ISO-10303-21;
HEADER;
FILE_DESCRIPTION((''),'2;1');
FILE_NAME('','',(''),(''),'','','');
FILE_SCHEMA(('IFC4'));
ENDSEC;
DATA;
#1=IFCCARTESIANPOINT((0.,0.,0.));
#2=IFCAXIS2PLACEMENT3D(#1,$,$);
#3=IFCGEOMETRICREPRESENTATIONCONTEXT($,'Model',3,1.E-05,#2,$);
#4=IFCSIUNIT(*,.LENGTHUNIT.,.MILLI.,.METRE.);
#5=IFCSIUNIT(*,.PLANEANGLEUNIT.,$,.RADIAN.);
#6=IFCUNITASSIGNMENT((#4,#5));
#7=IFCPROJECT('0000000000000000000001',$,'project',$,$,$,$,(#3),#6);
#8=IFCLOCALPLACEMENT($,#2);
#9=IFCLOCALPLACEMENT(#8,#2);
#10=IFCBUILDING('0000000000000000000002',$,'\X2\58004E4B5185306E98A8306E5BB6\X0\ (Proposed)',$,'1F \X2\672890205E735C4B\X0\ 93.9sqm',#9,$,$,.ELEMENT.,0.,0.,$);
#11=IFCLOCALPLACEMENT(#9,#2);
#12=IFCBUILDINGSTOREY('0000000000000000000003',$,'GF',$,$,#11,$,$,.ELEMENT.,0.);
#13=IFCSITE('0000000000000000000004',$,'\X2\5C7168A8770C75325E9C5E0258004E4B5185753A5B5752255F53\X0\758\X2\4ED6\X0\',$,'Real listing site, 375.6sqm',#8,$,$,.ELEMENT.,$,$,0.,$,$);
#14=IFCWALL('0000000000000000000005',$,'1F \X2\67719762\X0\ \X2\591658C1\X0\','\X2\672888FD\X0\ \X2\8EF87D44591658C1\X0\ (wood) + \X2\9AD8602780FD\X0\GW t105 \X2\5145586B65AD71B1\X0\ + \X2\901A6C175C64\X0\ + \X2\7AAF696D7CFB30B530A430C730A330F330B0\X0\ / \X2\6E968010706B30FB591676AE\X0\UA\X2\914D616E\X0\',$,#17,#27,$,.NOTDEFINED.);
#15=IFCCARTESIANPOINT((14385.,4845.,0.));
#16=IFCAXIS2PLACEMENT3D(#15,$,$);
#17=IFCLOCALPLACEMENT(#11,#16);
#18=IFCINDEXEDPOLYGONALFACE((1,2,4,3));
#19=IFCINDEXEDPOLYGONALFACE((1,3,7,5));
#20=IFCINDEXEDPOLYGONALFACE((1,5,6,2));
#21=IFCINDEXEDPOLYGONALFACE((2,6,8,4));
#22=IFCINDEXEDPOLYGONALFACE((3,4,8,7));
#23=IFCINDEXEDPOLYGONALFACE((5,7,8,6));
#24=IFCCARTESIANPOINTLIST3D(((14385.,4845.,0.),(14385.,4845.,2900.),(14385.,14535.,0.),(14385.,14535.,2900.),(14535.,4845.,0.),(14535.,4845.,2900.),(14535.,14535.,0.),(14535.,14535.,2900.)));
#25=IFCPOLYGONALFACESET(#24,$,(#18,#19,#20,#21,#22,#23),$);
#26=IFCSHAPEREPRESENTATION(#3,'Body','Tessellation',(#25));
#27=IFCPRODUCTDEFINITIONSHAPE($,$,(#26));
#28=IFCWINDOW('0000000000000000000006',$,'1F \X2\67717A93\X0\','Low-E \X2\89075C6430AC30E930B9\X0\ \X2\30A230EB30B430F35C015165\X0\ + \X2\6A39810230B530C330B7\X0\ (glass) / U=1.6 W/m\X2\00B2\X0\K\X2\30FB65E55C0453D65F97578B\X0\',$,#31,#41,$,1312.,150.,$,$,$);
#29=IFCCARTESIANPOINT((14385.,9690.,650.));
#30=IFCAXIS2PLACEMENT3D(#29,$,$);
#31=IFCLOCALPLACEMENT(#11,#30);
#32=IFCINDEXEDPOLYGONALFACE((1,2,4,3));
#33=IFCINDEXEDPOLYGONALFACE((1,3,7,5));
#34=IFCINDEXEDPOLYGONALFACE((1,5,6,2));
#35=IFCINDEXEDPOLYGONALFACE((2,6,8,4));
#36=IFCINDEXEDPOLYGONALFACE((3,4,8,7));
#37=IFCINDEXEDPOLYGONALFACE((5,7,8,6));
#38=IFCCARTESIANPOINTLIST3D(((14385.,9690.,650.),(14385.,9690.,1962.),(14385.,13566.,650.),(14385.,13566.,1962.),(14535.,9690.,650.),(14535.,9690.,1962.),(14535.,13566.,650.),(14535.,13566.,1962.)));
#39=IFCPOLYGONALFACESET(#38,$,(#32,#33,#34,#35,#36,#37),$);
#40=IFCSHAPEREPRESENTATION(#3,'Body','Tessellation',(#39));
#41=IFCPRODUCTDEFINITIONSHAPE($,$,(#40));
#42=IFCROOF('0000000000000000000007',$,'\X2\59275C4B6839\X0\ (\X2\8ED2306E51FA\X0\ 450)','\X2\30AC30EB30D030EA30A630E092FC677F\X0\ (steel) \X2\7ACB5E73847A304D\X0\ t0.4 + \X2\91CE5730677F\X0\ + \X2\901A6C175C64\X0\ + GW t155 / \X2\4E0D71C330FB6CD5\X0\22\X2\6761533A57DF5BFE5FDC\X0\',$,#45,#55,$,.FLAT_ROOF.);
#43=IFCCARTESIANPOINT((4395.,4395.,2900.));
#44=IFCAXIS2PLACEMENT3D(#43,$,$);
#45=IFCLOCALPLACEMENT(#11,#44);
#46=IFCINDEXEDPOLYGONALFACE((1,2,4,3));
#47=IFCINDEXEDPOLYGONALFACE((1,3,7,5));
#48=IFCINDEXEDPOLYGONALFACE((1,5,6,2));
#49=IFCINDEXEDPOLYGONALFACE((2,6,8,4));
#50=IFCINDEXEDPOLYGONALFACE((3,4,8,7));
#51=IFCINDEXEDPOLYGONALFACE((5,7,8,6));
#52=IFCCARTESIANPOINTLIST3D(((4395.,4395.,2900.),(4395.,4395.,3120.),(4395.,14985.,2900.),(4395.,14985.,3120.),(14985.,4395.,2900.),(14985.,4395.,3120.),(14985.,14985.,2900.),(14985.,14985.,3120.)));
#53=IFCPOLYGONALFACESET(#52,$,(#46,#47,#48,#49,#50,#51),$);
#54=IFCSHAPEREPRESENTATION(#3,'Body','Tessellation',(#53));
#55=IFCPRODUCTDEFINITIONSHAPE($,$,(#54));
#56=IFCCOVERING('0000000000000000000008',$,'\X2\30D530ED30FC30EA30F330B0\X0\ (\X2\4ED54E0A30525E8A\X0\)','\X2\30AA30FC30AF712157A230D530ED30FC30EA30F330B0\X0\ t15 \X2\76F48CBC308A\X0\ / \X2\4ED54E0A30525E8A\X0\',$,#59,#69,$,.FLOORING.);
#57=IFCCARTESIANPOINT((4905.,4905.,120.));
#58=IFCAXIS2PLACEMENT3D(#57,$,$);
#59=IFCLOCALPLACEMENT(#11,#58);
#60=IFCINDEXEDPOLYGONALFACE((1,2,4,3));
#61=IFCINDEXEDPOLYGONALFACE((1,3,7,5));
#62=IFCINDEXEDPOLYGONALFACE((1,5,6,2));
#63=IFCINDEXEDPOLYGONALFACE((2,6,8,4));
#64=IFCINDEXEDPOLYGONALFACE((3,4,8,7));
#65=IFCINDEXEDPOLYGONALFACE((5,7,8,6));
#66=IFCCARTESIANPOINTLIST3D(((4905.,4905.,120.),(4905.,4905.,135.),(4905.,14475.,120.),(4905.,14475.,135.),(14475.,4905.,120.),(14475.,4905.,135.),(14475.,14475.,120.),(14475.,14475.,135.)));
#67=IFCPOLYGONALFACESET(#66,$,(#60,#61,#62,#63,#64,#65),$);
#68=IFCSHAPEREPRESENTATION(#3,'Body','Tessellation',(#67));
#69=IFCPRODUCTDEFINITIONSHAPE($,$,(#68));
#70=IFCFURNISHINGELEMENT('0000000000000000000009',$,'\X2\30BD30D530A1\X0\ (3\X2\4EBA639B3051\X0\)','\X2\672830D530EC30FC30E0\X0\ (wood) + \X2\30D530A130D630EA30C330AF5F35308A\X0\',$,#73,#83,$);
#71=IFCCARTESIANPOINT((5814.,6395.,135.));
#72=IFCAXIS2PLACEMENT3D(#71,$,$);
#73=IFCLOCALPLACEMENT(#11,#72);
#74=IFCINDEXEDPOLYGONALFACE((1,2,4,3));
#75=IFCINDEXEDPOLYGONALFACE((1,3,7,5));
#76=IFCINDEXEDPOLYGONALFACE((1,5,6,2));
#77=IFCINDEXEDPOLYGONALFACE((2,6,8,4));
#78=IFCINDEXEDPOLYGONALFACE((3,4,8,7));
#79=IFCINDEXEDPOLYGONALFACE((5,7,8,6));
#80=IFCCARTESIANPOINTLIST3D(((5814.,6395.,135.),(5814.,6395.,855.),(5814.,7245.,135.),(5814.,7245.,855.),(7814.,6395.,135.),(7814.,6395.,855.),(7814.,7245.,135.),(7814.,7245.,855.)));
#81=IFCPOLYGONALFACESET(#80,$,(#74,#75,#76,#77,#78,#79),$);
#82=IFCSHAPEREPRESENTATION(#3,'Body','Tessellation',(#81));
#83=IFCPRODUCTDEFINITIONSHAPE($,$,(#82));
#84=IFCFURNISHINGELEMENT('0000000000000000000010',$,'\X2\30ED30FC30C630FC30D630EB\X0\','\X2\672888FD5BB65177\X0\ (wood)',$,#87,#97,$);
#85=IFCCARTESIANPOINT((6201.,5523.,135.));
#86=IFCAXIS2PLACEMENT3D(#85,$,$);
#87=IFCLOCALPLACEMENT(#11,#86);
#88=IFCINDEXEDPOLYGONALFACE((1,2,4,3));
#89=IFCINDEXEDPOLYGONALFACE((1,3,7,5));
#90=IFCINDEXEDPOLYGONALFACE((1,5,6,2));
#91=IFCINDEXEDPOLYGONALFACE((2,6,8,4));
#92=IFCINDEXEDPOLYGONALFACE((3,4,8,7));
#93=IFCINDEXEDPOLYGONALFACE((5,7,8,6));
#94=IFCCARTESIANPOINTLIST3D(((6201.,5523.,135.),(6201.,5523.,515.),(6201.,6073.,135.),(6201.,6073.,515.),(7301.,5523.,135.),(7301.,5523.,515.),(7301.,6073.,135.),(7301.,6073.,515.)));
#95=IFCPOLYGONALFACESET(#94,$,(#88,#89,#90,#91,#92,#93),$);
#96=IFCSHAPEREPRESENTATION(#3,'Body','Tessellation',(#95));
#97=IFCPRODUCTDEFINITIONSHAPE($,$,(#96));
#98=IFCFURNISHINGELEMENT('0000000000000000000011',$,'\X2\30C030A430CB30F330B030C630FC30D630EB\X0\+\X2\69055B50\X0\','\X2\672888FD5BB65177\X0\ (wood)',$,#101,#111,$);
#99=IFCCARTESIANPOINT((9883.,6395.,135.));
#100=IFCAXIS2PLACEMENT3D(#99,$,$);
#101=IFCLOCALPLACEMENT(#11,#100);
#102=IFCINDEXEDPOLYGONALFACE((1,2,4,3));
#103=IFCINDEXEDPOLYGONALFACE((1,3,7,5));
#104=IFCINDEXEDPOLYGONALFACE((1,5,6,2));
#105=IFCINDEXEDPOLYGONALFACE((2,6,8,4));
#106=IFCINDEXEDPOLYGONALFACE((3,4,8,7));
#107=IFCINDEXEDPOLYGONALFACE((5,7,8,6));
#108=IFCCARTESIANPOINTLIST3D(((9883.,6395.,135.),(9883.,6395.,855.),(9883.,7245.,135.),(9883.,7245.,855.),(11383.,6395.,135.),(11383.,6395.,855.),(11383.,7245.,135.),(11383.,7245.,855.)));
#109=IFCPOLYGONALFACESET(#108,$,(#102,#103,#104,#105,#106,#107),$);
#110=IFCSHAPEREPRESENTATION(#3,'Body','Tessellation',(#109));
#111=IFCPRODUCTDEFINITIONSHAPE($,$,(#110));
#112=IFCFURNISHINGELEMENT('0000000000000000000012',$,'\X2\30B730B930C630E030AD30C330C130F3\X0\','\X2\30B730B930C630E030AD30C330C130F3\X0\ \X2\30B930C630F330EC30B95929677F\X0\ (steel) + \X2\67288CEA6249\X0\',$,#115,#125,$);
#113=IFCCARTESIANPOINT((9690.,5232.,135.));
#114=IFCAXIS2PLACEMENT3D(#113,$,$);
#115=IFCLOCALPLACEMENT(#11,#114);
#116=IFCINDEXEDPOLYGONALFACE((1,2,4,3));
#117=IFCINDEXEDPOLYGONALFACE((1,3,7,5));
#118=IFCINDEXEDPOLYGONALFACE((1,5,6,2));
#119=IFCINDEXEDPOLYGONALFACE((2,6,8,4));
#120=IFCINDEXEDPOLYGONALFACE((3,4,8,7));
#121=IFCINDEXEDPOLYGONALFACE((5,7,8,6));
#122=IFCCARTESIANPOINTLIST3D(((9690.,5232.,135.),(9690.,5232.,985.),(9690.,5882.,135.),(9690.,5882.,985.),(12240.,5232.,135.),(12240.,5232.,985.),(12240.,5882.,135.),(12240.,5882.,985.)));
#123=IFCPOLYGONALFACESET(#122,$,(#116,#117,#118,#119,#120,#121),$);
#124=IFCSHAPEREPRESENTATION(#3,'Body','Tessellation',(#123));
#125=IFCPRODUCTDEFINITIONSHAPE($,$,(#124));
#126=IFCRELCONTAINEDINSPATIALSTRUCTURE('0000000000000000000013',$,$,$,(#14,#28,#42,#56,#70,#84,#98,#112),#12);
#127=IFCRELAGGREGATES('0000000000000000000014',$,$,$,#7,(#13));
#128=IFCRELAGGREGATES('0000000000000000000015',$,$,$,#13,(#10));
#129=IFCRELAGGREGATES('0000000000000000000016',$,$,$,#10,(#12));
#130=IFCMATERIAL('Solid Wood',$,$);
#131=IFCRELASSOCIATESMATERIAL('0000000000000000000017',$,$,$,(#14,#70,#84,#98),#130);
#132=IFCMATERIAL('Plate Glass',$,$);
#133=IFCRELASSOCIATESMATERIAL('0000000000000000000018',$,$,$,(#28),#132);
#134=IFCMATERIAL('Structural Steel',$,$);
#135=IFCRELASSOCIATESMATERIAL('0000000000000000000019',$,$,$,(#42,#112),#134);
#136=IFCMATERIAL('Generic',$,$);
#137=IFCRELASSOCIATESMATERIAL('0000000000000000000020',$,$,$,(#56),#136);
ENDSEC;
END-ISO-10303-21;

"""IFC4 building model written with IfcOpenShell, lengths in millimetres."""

from ifc_helpers import new_model, si_unit, frame, frame_2d, origin, place, context, project, spatial, rectangle, extrude, material, element, fill, save


model = new_model("IFC4")

# Units and contexts
model_context = context("Model", 3, precision=1e-05, world=origin())
ifc_project = project(units=[si_unit("LENGTHUNIT", "METRE", prefix="MILLI"), si_unit("PLANEANGLEUNIT", "RADIAN")], contexts=[model_context])

# Site, building, storey
site_placement = place(None, origin())
site = spatial("IfcSite", under=ifc_project, at=site_placement, Name="山梨県甲府市堀之内町字別当758他", ObjectType="Real listing site, 375.6sqm", CompositionType="ELEMENT", RefElevation=0.0)
building_placement = place(site_placement, origin())
building = spatial("IfcBuilding", under=site, at=building_placement, Name="堀之内の風の家 (Proposed)", ObjectType="1F 木造平屋 93.9sqm", CompositionType="ELEMENT", ElevationOfRefHeight=0.0, ElevationOfTerrain=0.0)
storey_placement = place(building_placement, origin())
storey = spatial("IfcBuildingStorey", under=building, at=storey_placement, Name="GF", CompositionType="ELEMENT", Elevation=0.0)

# Shared definitions
ifc_material_1 = material(Name="Solid Wood")

# Shared definitions
ifc_material_2 = material(Name="Plate Glass")

# Wall, opening, window
wall_1_placement = place(storey_placement, frame((14385.0, 4845.0, 0.0)))
wall_1 = element("IfcWall", 1, at=wall_1_placement, inside=storey, material=ifc_material_1, Name="1F 東面 外壁", Description="木製 軸組外壁 (wood) + 高性能GW t105 充填断熱 + 通気層 + 窯業系サイディング / 準耐火・外皮UA配慮", PredefinedType="NOTDEFINED", context=model_context, shape_type="SweptSolid", body=[
    extrude(rectangle(XDim=150.0, YDim=9690.0, at=frame_2d((75.0, 4845.0))), frame((14385.0, 4845.0, 0.0)), (0.0, 0.0, 1.0), 2900.0),
])
opening_1_placement = place(storey_placement, frame((14385.0, 9690.0, 650.0)))
opening_1 = element("IfcOpeningElement", 2, at=opening_1_placement, cuts=wall_1, PredefinedType="NOTDEFINED", context=model_context, shape_type="SweptSolid", body=[
    extrude(rectangle(XDim=150.0, YDim=3876.0, at=frame_2d((75.0, 1938.0))), frame((14385.0, 9690.0, 650.0)), (0.0, 0.0, 1.0), 1312.0),
])
window_1_placement = place(storey_placement, frame((14385.0, 9690.0, 650.0)))
window_1 = element("IfcWindow", 3, at=window_1_placement, inside=storey, material=ifc_material_2, Name="1F 東窓", Description="Low-E 複層ガラス アルゴン封入 + 樹脂サッシ (glass) / U=1.6 W/m²K・日射取得型", OverallHeight=1312.0, OverallWidth=150.0, context=model_context, shape_type="SweptSolid", body=[
    extrude(rectangle(XDim=150.0, YDim=3876.0, at=frame_2d((75.0, 1938.0))), frame((14385.0, 9690.0, 650.0)), (0.0, 0.0, 1.0), 1312.0),
])
fill(opening_1, window_1)

# Roof
ifc_material_3 = material(Name="Structural Steel")
roof_placement = place(storey_placement, frame((4395.0, 4395.0, 2900.0)))
element("IfcRoof", 4, at=roof_placement, inside=storey, material=ifc_material_3, Name="大屋根 (軒の出 450)", Description="ガルバリウム鋼板 (steel) 立平葺き t0.4 + 野地板 + 通気層 + GW t155 / 不燃・法22条区域対応", PredefinedType="FLAT_ROOF", context=model_context, shape_type="SweptSolid", body=[
    extrude(rectangle(XDim=10590.0, YDim=10590.0, at=frame_2d((5295.0, 5295.0))), frame((4395.0, 4395.0, 2900.0)), (0.0, 0.0, 1.0), 220.0),
])

# Covering
ifc_material_4 = material(Name="Generic")
covering_placement = place(storey_placement, frame((4905.0, 4905.0, 120.0)))
element("IfcCovering", 5, at=covering_placement, inside=storey, material=ifc_material_4, Name="フローリング (仕上げ床)", Description="オーク無垢フローリング t15 直貼り / 仕上げ床", PredefinedType="FLOORING", context=model_context, shape_type="SweptSolid", body=[
    extrude(rectangle(XDim=9570.0, YDim=9570.0, at=frame_2d((4785.0, 4785.0))), frame((4905.0, 4905.0, 120.0)), (0.0, 0.0, 1.0), 15.0),
])

# Furnishing elements
furnishing_1_placement = place(storey_placement, frame((5814.0, 6395.0, 135.0)))
element("IfcFurnishingElement", 6, at=furnishing_1_placement, inside=storey, material=ifc_material_1, Name="ソファ (3人掛け)", Description="木フレーム (wood) + ファブリック張り", context=model_context, shape_type="SweptSolid", body=[
    extrude(rectangle(XDim=2000.0, YDim=850.0, at=frame_2d((1000.0, 425.0))), frame((5814.0, 6395.0, 135.0)), (0.0, 0.0, 1.0), 720.0),
])
furnishing_2_placement = place(storey_placement, frame((6201.0, 5523.0, 135.0)))
element("IfcFurnishingElement", 7, at=furnishing_2_placement, inside=storey, material=ifc_material_1, Name="ローテーブル", Description="木製家具 (wood)", context=model_context, shape_type="SweptSolid", body=[
    extrude(rectangle(XDim=1100.0, YDim=550.0, at=frame_2d((550.0, 275.0))), frame((6201.0, 5523.0, 135.0)), (0.0, 0.0, 1.0), 380.0),
])
furnishing_3_placement = place(storey_placement, frame((9883.0, 6395.0, 135.0)))
element("IfcFurnishingElement", 8, at=furnishing_3_placement, inside=storey, material=ifc_material_1, Name="ダイニングテーブル+椅子", Description="木製家具 (wood)", context=model_context, shape_type="SweptSolid", body=[
    extrude(rectangle(XDim=1500.0, YDim=850.0, at=frame_2d((750.0, 425.0))), frame((9883.0, 6395.0, 135.0)), (0.0, 0.0, 1.0), 720.0),
])
furnishing_4_placement = place(storey_placement, frame((9690.0, 5232.0, 135.0)))
element("IfcFurnishingElement", 9, at=furnishing_4_placement, inside=storey, material=ifc_material_3, Name="システムキッチン", Description="システムキッチン ステンレス天板 (steel) + 木質扉", context=model_context, shape_type="SweptSolid", body=[
    extrude(rectangle(XDim=2550.0, YDim=650.0, at=frame_2d((1275.0, 325.0))), frame((9690.0, 5232.0, 135.0)), (0.0, 0.0, 1.0), 850.0),
])

save(model, "model.ifc")
